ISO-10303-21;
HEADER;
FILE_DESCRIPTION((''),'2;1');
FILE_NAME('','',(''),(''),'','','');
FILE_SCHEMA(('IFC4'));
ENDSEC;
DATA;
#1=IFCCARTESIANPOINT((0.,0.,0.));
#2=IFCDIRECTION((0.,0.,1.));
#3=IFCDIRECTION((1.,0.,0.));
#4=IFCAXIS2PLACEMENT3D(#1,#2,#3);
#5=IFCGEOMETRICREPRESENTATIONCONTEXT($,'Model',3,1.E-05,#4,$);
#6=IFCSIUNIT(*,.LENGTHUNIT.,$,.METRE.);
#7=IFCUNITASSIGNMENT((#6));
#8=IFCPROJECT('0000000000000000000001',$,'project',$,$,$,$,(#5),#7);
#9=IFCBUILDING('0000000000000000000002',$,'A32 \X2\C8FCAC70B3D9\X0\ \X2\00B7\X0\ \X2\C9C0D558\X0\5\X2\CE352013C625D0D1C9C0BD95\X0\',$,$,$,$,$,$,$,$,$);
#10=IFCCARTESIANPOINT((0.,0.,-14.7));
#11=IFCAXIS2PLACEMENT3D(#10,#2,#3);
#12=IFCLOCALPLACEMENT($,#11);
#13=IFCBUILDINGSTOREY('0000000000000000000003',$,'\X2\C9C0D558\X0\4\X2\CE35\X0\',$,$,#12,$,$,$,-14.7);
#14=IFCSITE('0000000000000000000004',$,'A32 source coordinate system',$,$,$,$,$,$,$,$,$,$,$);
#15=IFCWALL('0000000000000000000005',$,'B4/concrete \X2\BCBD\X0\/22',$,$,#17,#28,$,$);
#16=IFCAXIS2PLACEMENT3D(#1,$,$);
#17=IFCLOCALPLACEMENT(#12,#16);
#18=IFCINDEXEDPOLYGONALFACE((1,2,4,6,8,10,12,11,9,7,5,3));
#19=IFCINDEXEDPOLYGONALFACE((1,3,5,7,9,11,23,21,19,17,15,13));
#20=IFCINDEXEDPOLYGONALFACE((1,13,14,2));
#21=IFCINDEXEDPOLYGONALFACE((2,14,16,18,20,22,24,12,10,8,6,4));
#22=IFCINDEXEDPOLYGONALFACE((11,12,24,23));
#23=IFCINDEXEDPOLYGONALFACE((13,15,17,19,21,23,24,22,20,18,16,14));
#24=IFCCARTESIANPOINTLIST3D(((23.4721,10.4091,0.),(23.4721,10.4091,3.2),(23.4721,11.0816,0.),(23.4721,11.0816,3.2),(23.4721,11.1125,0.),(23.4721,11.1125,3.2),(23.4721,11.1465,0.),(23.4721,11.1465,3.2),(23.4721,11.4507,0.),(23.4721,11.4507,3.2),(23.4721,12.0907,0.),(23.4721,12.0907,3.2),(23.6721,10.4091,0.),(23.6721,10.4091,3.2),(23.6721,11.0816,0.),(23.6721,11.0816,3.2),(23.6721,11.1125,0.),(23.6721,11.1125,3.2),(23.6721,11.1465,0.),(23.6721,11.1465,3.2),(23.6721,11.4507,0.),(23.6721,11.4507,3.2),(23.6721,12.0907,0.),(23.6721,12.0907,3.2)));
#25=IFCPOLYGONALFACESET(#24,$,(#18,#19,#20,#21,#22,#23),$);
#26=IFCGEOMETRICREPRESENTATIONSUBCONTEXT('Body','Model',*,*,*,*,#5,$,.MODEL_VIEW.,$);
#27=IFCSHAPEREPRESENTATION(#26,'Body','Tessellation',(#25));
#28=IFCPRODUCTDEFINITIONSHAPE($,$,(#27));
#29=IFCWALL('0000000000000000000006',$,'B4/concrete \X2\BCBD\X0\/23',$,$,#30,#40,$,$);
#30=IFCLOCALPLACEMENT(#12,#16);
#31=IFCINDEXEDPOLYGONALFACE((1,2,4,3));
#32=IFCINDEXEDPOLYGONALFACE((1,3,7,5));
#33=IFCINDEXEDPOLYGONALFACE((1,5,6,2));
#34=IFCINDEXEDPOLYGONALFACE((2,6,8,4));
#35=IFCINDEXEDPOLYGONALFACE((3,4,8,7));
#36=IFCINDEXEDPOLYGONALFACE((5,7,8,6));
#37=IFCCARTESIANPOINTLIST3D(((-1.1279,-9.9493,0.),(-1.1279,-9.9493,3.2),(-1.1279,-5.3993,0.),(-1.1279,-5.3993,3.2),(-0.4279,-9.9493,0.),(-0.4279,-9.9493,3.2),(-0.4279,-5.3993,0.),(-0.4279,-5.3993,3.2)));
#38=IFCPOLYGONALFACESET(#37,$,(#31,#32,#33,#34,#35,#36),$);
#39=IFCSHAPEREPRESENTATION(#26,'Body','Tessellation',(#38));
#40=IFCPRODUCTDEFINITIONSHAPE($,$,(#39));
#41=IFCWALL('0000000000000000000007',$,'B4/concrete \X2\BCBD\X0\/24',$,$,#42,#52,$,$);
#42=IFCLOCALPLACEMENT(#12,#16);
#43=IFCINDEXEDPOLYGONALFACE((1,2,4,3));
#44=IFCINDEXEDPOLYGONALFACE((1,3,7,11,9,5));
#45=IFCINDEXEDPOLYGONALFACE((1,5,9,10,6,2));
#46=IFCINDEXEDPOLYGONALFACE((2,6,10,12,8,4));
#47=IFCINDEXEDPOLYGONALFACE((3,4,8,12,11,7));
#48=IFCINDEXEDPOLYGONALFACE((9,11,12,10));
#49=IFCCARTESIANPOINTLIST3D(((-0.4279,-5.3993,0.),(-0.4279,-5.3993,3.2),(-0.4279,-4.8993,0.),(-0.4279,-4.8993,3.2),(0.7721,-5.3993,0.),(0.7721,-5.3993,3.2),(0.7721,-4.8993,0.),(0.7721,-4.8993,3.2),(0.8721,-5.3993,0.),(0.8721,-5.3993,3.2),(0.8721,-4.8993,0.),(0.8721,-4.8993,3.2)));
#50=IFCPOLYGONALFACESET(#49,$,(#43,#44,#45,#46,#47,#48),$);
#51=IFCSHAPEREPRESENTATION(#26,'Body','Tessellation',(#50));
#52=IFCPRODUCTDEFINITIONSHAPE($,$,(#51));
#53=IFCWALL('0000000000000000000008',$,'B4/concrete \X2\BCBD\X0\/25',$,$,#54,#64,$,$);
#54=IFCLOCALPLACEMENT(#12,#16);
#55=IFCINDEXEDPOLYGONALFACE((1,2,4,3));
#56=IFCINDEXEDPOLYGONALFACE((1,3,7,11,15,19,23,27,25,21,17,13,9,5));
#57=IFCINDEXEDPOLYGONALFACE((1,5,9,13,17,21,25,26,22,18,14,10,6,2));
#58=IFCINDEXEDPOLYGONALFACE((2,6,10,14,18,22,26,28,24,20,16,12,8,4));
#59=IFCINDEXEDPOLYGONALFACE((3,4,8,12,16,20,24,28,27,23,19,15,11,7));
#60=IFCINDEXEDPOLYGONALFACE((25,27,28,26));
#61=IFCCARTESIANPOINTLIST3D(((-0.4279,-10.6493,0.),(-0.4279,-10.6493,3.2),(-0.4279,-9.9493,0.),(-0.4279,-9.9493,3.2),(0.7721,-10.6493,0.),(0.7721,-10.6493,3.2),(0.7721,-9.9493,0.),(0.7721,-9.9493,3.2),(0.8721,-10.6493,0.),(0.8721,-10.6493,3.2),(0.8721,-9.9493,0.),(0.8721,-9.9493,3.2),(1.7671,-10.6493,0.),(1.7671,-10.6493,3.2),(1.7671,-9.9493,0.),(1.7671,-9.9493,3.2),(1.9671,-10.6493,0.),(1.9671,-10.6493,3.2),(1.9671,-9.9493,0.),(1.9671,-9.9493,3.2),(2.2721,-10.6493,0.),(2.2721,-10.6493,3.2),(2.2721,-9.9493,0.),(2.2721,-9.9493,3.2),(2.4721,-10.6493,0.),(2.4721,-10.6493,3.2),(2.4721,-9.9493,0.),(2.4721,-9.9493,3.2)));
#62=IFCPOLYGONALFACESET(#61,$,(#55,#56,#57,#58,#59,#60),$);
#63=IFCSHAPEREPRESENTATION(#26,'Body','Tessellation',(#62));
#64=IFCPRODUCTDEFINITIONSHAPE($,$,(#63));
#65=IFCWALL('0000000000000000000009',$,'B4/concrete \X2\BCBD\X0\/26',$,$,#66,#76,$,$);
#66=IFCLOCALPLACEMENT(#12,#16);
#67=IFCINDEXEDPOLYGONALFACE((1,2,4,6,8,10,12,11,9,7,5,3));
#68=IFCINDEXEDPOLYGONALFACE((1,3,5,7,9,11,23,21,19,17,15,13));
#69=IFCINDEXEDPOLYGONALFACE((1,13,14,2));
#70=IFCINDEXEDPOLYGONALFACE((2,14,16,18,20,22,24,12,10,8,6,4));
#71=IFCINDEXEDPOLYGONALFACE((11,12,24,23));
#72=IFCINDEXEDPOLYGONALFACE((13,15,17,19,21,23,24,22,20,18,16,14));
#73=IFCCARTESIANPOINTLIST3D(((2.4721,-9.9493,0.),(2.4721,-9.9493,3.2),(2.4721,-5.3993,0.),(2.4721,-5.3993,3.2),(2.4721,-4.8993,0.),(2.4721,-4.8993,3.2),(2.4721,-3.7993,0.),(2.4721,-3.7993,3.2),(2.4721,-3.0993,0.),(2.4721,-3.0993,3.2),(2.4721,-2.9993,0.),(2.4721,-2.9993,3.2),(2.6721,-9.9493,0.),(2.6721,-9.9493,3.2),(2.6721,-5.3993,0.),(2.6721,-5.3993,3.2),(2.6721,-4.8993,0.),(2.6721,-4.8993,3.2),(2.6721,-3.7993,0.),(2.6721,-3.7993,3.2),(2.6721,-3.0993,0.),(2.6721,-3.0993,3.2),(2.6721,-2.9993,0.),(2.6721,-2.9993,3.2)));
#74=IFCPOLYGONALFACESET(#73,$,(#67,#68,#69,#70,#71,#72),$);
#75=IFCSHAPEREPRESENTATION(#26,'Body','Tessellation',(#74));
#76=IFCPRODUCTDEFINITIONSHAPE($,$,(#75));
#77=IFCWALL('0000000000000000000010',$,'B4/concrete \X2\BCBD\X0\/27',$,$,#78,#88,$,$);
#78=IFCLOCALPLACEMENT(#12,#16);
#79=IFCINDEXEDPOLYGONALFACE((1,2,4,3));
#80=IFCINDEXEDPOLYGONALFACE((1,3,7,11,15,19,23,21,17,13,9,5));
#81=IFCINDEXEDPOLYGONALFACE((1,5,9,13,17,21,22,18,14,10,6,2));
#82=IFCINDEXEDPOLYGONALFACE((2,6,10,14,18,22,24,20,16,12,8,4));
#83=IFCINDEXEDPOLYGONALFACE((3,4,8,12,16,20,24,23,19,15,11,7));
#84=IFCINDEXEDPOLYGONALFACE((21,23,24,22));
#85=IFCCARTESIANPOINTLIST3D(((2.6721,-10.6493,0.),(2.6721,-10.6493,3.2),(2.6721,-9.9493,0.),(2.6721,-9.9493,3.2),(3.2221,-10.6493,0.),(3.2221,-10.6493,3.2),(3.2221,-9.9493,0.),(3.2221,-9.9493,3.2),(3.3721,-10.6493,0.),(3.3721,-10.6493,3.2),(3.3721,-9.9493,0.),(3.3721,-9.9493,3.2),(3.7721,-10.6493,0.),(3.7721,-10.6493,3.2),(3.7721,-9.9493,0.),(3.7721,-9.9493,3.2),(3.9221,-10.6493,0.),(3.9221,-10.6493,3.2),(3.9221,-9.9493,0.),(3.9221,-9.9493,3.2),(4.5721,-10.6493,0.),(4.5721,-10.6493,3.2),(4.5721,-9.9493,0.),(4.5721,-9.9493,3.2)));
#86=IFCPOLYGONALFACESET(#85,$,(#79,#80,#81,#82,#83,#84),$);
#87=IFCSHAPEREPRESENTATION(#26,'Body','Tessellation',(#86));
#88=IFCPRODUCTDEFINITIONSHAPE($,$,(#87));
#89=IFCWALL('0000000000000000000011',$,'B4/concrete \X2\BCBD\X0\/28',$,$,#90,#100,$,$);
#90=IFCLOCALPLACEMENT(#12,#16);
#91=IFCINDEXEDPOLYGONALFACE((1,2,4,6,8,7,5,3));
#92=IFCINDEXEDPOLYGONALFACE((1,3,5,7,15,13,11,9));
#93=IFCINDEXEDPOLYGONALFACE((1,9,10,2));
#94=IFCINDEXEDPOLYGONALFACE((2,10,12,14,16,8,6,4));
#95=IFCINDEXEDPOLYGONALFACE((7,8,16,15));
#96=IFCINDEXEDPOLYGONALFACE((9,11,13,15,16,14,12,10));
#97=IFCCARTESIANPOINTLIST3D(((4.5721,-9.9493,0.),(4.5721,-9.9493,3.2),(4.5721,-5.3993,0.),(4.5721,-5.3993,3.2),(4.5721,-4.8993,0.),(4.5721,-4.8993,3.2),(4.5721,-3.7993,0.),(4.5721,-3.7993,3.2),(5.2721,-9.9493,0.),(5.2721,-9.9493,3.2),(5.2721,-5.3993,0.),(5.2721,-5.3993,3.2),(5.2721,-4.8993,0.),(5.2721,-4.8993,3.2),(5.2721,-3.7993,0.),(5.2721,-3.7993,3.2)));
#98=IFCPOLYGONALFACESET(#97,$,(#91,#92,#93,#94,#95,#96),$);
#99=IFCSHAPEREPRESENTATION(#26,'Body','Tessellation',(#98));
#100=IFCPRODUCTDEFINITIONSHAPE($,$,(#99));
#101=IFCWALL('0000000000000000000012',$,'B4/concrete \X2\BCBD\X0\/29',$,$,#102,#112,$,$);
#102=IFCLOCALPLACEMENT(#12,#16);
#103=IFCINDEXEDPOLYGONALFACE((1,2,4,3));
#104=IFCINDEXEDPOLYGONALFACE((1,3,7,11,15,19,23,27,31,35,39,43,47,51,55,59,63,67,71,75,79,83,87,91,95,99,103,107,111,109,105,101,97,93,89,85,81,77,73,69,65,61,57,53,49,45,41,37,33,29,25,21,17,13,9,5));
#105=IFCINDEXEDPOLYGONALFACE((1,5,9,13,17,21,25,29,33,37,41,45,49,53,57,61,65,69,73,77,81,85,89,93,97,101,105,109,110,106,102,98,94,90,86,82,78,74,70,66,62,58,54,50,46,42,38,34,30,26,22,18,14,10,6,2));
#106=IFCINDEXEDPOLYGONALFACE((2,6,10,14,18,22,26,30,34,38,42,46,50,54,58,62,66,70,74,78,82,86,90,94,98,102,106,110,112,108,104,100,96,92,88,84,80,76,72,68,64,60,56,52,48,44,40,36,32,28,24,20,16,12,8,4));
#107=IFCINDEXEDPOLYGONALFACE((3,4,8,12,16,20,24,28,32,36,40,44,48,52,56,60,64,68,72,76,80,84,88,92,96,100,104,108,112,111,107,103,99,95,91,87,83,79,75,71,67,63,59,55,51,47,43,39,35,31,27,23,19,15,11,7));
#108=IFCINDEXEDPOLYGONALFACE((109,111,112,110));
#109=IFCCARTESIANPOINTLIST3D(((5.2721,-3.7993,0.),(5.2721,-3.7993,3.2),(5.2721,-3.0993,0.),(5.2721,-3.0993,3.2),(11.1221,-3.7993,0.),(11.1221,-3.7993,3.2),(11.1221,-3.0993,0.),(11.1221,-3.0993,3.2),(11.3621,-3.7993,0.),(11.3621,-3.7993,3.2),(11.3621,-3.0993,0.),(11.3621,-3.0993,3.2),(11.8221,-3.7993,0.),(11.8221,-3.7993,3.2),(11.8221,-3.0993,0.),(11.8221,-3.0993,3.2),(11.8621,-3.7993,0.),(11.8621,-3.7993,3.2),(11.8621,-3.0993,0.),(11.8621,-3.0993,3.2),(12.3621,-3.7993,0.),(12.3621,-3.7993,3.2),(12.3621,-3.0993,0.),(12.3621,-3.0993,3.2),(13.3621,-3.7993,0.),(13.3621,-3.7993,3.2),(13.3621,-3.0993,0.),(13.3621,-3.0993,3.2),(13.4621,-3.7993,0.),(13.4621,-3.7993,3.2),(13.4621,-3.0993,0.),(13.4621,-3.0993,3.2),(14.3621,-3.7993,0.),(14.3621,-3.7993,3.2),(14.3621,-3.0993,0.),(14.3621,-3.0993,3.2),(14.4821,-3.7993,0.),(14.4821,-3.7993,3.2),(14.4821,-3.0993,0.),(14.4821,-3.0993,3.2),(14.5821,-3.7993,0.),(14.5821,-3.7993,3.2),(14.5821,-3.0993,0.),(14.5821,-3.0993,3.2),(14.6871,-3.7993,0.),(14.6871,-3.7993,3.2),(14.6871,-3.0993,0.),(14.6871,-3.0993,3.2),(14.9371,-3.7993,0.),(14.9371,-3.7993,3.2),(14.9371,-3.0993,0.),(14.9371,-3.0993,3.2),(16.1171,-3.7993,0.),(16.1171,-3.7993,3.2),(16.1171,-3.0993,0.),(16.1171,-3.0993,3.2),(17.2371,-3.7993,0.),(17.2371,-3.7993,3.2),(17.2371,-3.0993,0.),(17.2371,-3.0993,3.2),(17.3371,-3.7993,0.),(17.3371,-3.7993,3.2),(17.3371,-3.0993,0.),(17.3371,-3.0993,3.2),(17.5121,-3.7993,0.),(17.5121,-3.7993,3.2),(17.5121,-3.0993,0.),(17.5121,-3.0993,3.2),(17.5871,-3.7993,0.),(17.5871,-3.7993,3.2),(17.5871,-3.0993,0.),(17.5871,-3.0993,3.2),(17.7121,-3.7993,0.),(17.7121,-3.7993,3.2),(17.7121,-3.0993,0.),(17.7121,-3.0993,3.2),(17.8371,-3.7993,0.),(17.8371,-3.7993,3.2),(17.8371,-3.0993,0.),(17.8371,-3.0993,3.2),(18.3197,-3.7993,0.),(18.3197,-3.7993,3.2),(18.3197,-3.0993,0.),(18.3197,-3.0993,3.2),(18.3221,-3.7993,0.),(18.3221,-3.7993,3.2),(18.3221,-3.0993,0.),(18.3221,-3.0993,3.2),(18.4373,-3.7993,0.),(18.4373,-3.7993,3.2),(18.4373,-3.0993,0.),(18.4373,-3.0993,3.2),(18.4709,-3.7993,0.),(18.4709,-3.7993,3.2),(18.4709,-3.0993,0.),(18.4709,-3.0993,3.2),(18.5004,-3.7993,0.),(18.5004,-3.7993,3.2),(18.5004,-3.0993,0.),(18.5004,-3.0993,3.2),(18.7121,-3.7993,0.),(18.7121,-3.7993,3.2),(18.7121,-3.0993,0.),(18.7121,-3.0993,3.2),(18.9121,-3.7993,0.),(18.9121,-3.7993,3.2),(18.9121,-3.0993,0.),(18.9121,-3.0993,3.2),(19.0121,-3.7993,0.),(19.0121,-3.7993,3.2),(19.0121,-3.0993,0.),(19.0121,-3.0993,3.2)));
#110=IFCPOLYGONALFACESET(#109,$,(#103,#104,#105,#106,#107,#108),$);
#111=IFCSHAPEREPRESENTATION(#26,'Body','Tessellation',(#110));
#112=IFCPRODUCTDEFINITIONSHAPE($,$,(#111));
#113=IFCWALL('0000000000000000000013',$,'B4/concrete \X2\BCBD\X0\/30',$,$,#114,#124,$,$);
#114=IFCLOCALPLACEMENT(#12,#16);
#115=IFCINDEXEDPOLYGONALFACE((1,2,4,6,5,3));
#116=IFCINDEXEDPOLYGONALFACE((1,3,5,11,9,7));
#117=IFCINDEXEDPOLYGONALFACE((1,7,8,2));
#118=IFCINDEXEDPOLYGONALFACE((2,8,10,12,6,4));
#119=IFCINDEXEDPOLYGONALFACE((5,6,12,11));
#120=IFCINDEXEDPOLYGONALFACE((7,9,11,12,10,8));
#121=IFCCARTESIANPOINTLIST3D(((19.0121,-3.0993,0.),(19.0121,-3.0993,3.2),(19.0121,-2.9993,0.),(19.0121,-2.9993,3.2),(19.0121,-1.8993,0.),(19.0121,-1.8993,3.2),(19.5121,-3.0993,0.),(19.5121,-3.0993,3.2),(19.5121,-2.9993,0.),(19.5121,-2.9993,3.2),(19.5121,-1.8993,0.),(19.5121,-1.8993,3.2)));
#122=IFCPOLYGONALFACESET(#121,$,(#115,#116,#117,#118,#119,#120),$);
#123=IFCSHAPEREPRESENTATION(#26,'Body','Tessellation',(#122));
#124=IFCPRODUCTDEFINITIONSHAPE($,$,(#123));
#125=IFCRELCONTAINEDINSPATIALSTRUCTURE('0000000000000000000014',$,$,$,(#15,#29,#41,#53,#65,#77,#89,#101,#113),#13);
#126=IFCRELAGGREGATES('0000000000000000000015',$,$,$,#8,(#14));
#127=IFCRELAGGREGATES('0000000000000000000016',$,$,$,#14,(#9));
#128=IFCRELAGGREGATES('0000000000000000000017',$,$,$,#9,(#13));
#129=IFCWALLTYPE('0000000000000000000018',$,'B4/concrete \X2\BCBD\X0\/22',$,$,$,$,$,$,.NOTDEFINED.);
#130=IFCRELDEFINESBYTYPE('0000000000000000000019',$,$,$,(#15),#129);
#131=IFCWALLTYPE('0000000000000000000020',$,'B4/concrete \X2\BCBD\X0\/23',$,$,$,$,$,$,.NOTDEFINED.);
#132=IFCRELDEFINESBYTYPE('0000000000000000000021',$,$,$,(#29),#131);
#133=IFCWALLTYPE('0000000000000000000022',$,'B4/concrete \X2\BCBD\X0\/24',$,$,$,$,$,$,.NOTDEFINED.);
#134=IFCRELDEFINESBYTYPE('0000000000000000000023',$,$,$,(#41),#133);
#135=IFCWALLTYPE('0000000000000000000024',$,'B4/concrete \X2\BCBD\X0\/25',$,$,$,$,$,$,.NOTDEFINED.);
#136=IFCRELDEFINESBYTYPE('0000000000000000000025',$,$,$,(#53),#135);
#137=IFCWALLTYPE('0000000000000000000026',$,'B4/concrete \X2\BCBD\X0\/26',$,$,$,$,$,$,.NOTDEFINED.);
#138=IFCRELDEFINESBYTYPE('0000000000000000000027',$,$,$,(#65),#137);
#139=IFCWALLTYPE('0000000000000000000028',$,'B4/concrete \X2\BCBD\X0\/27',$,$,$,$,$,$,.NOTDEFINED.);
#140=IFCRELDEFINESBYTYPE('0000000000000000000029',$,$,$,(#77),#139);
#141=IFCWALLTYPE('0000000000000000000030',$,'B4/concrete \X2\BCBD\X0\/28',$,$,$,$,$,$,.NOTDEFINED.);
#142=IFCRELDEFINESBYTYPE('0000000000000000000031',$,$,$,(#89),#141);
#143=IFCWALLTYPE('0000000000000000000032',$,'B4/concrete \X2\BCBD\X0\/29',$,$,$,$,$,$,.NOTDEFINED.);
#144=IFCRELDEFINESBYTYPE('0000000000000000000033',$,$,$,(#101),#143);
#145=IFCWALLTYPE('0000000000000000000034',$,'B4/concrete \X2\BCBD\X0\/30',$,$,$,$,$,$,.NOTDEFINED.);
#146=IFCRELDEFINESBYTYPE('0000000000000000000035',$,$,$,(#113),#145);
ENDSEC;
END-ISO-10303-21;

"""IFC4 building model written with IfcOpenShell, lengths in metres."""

from ifc_helpers import new_model, si_unit, frame, origin, origin_with_axes, place, context, subcontext, project, spatial, polyline, outline, extrude, source, transform, mapped, type_object, type_shapes, element, save


model = new_model("IFC4")

# Units and contexts
model_context = context("Model", 3, precision=1e-05, world=origin_with_axes())
body_context = subcontext(model_context, "Body", "Model", "MODEL_VIEW")
ifc_project = project(units=[si_unit("LENGTHUNIT", "METRE")], contexts=[model_context])

# Site, building, storey
site = spatial("IfcSite", under=ifc_project, Name="A32 source coordinate system")
building = spatial("IfcBuilding", under=site, Name="A32 주거동 · 지하5층–옥탑지붕")
storey_placement = place(None, frame((0.0, 0.0, -14.7), z_axis=(0.0, 0.0, 1.0), x_axis=(1.0, 0.0, 0.0)))
storey = spatial("IfcBuildingStorey", under=building, at=storey_placement, Name="지하4층", Elevation=-14.7)

# Walls
wall_type_1 = type_object("IfcWallType", Name="B4/concrete 벽/22", PredefinedType="NOTDEFINED")
shared_shape_1 = source(origin(), body_context, "Body", "SweptSolid", [
    extrude(outline(polyline([(23.6721, 11.1465), (23.6721, 11.1125), (23.6721, 11.0816), (23.6721, 10.4091), (23.4721, 10.4091), (23.4721, 11.0816), (23.4721, 11.1125), (23.4721, 11.1465), (23.4721, 11.4507), (23.4721, 12.0907), (23.6721, 12.0907), (23.6721, 11.4507), (23.6721, 11.1465)])), origin(), (0.0, 0.0, 1.0), 3.2),
])
type_shapes(wall_type_1, [shared_shape_1])
wall_1_placement = place(storey_placement, origin_with_axes())
element("IfcWall", 1, at=wall_1_placement, inside=storey, type_object=wall_type_1, Name="B4/concrete 벽/22", context=body_context, shape_type="MappedRepresentation", body=[
    mapped(shared_shape_1, transform((0.0, 0.0, 0.0), scale=1.0)),
])
wall_type_2 = type_object("IfcWallType", Name="B4/concrete 벽/23", PredefinedType="NOTDEFINED")
shared_shape_2 = source(origin(), body_context, "Body", "SweptSolid", [
    extrude(outline(polyline([(-0.4279, -9.9493), (-1.1279, -9.9493), (-1.1279, -5.3993), (-0.4279, -5.3993), (-0.4279, -9.9493)])), origin(), (0.0, 0.0, 1.0), 3.2),
])
type_shapes(wall_type_2, [shared_shape_2])
wall_2_placement = place(storey_placement, origin_with_axes())
element("IfcWall", 2, at=wall_2_placement, inside=storey, type_object=wall_type_2, Name="B4/concrete 벽/23", context=body_context, shape_type="MappedRepresentation", body=[
    mapped(shared_shape_2, transform((0.0, 0.0, 0.0), scale=1.0)),
])
wall_type_3 = type_object("IfcWallType", Name="B4/concrete 벽/24", PredefinedType="NOTDEFINED")
shared_shape_3 = source(origin(), body_context, "Body", "SweptSolid", [
    extrude(outline(polyline([(0.8721, -4.8993), (0.8721, -5.3993), (0.7721, -5.3993), (-0.4279, -5.3993), (-0.4279, -4.8993), (0.7721, -4.8993), (0.8721, -4.8993)])), origin(), (0.0, 0.0, 1.0), 3.2),
])
type_shapes(wall_type_3, [shared_shape_3])
wall_3_placement = place(storey_placement, origin_with_axes())
element("IfcWall", 3, at=wall_3_placement, inside=storey, type_object=wall_type_3, Name="B4/concrete 벽/24", context=body_context, shape_type="MappedRepresentation", body=[
    mapped(shared_shape_3, transform((0.0, 0.0, 0.0), scale=1.0)),
])
wall_type_4 = type_object("IfcWallType", Name="B4/concrete 벽/25", PredefinedType="NOTDEFINED")
shared_shape_4 = source(origin(), body_context, "Body", "SweptSolid", [
    extrude(outline(polyline([(1.7671, -9.9493), (1.9671, -9.9493), (2.2721, -9.9493), (2.4721, -9.9493), (2.4721, -10.6493), (2.2721, -10.6493), (1.9671, -10.6493), (1.7671, -10.6493), (0.8721, -10.6493), (0.7721, -10.6493), (-0.4279, -10.6493), (-0.4279, -9.9493), (0.7721, -9.9493), (0.8721, -9.9493), (1.7671, -9.9493)])), origin(), (0.0, 0.0, 1.0), 3.2),
])
type_shapes(wall_type_4, [shared_shape_4])
wall_4_placement = place(storey_placement, origin_with_axes())
element("IfcWall", 4, at=wall_4_placement, inside=storey, type_object=wall_type_4, Name="B4/concrete 벽/25", context=body_context, shape_type="MappedRepresentation", body=[
    mapped(shared_shape_4, transform((0.0, 0.0, 0.0), scale=1.0)),
])
wall_type_5 = type_object("IfcWallType", Name="B4/concrete 벽/26", PredefinedType="NOTDEFINED")
shared_shape_5 = source(origin(), body_context, "Body", "SweptSolid", [
    extrude(outline(polyline([(2.4721, -3.7993), (2.4721, -3.0993), (2.4721, -2.9993), (2.6721, -2.9993), (2.6721, -3.0993), (2.6721, -3.7993), (2.6721, -4.8993), (2.6721, -5.3993), (2.6721, -9.9493), (2.4721, -9.9493), (2.4721, -5.3993), (2.4721, -4.8993), (2.4721, -3.7993)])), origin(), (0.0, 0.0, 1.0), 3.2),
])
type_shapes(wall_type_5, [shared_shape_5])
wall_5_placement = place(storey_placement, origin_with_axes())
element("IfcWall", 5, at=wall_5_placement, inside=storey, type_object=wall_type_5, Name="B4/concrete 벽/26", context=body_context, shape_type="MappedRepresentation", body=[
    mapped(shared_shape_5, transform((0.0, 0.0, 0.0), scale=1.0)),
])
wall_type_6 = type_object("IfcWallType", Name="B4/concrete 벽/27", PredefinedType="NOTDEFINED")
shared_shape_6 = source(origin(), body_context, "Body", "SweptSolid", [
    extrude(outline(polyline([(3.7721, -9.9493), (3.9221, -9.9493), (4.5721, -9.9493), (4.5721, -10.6493), (3.9221, -10.6493), (3.7721, -10.6493), (3.3721, -10.6493), (3.2221, -10.6493), (2.6721, -10.6493), (2.6721, -9.9493), (3.2221, -9.9493), (3.3721, -9.9493), (3.7721, -9.9493)])), origin(), (0.0, 0.0, 1.0), 3.2),
])
type_shapes(wall_type_6, [shared_shape_6])
wall_6_placement = place(storey_placement, origin_with_axes())
element("IfcWall", 6, at=wall_6_placement, inside=storey, type_object=wall_type_6, Name="B4/concrete 벽/27", context=body_context, shape_type="MappedRepresentation", body=[
    mapped(shared_shape_6, transform((0.0, 0.0, 0.0), scale=1.0)),
])
wall_type_7 = type_object("IfcWallType", Name="B4/concrete 벽/28", PredefinedType="NOTDEFINED")
shared_shape_7 = source(origin(), body_context, "Body", "SweptSolid", [
    extrude(outline(polyline([(4.5721, -3.7993), (5.2721, -3.7993), (5.2721, -4.8993), (5.2721, -5.3993), (5.2721, -9.9493), (4.5721, -9.9493), (4.5721, -5.3993), (4.5721, -4.8993), (4.5721, -3.7993)])), origin(), (0.0, 0.0, 1.0), 3.2),
])
type_shapes(wall_type_7, [shared_shape_7])
wall_7_placement = place(storey_placement, origin_with_axes())
element("IfcWall", 7, at=wall_7_placement, inside=storey, type_object=wall_type_7, Name="B4/concrete 벽/28", context=body_context, shape_type="MappedRepresentation", body=[
    mapped(shared_shape_7, transform((0.0, 0.0, 0.0), scale=1.0)),
])
wall_type_8 = type_object("IfcWallType", Name="B4/concrete 벽/29", PredefinedType="NOTDEFINED")
shared_shape_8 = source(origin(), body_context, "Body", "SweptSolid", [
    extrude(outline(polyline([(11.3621, -3.0993), (11.8221, -3.0993), (11.8621, -3.0993), (12.3621, -3.0993), (13.3621, -3.0993), (13.4621, -3.0993), (14.3621, -3.0993), (14.4821, -3.0993), (14.5821, -3.0993), (14.6871, -3.0993), (14.9371, -3.0993), (16.1171, -3.0993), (17.2371, -3.0993), (17.3371, -3.0993), (17.5121, -3.0993), (17.5871, -3.0993), (17.7121, -3.0993), (17.8371, -3.0993), (18.3197, -3.0993), (18.3221, -3.0993), (18.4373, -3.0993), (18.4709, -3.0993), (18.5004, -3.0993), (18.7121, -3.0993), (18.9121, -3.0993), (19.0121, -3.0993), (19.0121, -3.7993), (18.9121, -3.7993), (18.7121, -3.7993), (18.5004, -3.7993), (18.4709, -3.7993), (18.4373, -3.7993), (18.3221, -3.7993), (18.3197, -3.7993), (17.8371, -3.7993), (17.7121, -3.7993), (17.5871, -3.7993), (17.5121, -3.7993), (17.3371, -3.7993), (17.2371, -3.7993), (16.1171, -3.7993), (14.9371, -3.7993), (14.6871, -3.7993), (14.5821, -3.7993), (14.4821, -3.7993), (14.3621, -3.7993), (13.4621, -3.7993), (13.3621, -3.7993), (12.3621, -3.7993), (11.8621, -3.7993), (11.8221, -3.7993), (11.3621, -3.7993), (11.1221, -3.7993), (5.2721, -3.7993), (5.2721, -3.0993), (11.1221, -3.0993), (11.3621, -3.0993)])), origin(), (0.0, 0.0, 1.0), 3.2),
])
type_shapes(wall_type_8, [shared_shape_8])
wall_8_placement = place(storey_placement, origin_with_axes())
element("IfcWall", 8, at=wall_8_placement, inside=storey, type_object=wall_type_8, Name="B4/concrete 벽/29", context=body_context, shape_type="MappedRepresentation", body=[
    mapped(shared_shape_8, transform((0.0, 0.0, 0.0), scale=1.0)),
])
wall_type_9 = type_object("IfcWallType", Name="B4/concrete 벽/30", PredefinedType="NOTDEFINED")
shared_shape_9 = source(origin(), body_context, "Body", "SweptSolid", [
    extrude(outline(polyline([(19.5121, -1.8993), (19.5121, -2.9993), (19.5121, -3.0993), (19.0121, -3.0993), (19.0121, -2.9993), (19.0121, -1.8993), (19.5121, -1.8993)])), origin(), (0.0, 0.0, 1.0), 3.2),
])
type_shapes(wall_type_9, [shared_shape_9])
wall_9_placement = place(storey_placement, origin_with_axes())
element("IfcWall", 9, at=wall_9_placement, inside=storey, type_object=wall_type_9, Name="B4/concrete 벽/30", context=body_context, shape_type="MappedRepresentation", body=[
    mapped(shared_shape_9, transform((0.0, 0.0, 0.0), scale=1.0)),
])

save(model, "model.ifc")
